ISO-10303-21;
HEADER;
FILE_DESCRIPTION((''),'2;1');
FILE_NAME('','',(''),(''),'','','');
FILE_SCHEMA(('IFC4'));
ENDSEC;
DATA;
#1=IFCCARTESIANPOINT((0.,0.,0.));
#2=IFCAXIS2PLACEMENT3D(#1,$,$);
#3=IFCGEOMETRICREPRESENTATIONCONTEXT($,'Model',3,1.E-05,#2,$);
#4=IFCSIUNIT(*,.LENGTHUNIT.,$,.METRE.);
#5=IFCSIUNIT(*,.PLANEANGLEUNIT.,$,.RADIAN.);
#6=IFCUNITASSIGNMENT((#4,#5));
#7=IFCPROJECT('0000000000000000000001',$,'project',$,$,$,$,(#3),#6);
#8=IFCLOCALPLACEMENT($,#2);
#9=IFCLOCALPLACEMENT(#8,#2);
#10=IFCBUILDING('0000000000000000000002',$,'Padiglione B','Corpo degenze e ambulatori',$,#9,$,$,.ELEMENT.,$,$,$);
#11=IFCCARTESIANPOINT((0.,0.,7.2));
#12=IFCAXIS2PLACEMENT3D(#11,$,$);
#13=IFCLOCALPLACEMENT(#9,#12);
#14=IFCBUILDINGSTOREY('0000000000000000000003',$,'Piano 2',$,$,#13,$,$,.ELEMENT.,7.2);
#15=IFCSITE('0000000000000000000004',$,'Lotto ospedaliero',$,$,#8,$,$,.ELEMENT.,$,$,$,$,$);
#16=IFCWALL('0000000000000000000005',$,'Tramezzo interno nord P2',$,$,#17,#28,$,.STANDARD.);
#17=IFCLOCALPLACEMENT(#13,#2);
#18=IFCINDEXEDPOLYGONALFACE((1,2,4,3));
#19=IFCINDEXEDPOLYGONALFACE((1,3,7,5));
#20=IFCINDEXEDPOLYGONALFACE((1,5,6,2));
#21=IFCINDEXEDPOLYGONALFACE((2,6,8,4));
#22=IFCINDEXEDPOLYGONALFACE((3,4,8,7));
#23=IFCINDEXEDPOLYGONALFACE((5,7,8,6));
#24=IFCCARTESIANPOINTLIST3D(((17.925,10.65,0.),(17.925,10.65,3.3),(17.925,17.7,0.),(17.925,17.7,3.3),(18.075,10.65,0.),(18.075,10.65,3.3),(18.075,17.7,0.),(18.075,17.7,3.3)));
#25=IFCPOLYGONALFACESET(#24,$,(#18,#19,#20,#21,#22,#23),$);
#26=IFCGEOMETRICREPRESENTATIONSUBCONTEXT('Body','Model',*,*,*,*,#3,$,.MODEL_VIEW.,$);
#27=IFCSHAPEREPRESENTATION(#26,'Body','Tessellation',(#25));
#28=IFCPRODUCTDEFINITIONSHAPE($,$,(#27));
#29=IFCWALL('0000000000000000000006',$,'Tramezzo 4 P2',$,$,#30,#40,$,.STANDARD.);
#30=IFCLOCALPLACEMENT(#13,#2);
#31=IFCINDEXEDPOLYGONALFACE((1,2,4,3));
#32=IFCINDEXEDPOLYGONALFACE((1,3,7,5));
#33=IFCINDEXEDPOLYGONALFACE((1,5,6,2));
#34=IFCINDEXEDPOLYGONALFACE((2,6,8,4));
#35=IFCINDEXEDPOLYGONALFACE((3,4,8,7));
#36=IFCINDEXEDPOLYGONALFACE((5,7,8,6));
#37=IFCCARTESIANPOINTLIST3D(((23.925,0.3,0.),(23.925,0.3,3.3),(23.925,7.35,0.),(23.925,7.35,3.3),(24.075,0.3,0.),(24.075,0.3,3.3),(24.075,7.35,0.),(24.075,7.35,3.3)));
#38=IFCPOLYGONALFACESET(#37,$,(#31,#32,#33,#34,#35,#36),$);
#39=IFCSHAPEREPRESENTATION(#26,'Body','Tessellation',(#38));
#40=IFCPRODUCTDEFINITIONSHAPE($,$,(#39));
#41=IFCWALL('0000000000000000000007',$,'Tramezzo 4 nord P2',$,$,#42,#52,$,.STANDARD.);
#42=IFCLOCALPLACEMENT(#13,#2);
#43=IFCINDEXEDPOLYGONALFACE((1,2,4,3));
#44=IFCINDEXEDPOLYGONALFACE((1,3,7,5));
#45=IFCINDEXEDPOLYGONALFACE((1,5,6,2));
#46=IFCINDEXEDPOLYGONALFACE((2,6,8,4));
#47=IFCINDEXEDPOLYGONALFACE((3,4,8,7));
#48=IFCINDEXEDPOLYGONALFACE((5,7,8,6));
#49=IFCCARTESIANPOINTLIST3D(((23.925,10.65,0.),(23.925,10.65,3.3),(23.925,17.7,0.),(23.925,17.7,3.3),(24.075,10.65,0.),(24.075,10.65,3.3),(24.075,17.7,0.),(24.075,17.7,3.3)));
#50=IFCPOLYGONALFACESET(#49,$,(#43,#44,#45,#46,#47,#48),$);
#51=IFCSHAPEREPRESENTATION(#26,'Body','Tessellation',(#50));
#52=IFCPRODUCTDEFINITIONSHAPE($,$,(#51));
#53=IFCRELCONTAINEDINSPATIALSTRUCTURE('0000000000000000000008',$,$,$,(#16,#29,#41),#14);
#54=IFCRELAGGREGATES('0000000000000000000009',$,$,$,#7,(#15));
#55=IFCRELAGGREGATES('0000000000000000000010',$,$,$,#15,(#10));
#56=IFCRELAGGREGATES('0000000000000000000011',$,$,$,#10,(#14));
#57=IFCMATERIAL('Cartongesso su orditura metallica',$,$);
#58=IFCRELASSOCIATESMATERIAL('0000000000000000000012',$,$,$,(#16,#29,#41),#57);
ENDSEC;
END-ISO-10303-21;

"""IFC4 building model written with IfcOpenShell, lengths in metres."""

from ifc_helpers import new_model, si_unit, frame, frame_2d, origin, place, context, subcontext, project, spatial, rectangle, extrude, material, element, save


model = new_model("IFC4")

# Units and contexts
model_context = context("Model", 3, precision=1e-05, world=origin())
body_context = subcontext(model_context, "Body", "Model", "MODEL_VIEW")
ifc_project = project(units=[si_unit("LENGTHUNIT", "METRE"), si_unit("PLANEANGLEUNIT", "RADIAN")], contexts=[model_context])

# Site, building, storey
site_placement = place(None, origin())
site = spatial("IfcSite", under=ifc_project, at=site_placement, Name="Lotto ospedaliero", CompositionType="ELEMENT")
building_placement = place(site_placement, origin())
building = spatial("IfcBuilding", under=site, at=building_placement, Name="Padiglione B", Description="Corpo degenze e ambulatori", CompositionType="ELEMENT")
storey_placement = place(building_placement, frame((0.0, 0.0, 7.2)))
storey = spatial("IfcBuildingStorey", under=building, at=storey_placement, Name="Piano 2", CompositionType="ELEMENT", Elevation=7.2)

# Walls
ifc_material_1 = material(Name="Cartongesso su orditura metallica")
for number, where, name in (
    (1, (17.925, 10.65, 0.0), "Tramezzo interno nord P2"),
    (2, (23.925, 0.3, 0.0), "Tramezzo 4 P2"),
    (3, (23.925, 10.65, 0.0), "Tramezzo 4 nord P2"),
):
    element("IfcWall", number, at=place(storey_placement, frame(where)), inside=storey, material=ifc_material_1, Name=name, PredefinedType="STANDARD", context=body_context, shape_type="SweptSolid", body=[
        extrude(rectangle(XDim=0.15, YDim=7.05, at=frame_2d((0.075, 3.525))), origin(), (0.0, 0.0, 1.0), 3.3),
    ])

save(model, "model.ifc")
